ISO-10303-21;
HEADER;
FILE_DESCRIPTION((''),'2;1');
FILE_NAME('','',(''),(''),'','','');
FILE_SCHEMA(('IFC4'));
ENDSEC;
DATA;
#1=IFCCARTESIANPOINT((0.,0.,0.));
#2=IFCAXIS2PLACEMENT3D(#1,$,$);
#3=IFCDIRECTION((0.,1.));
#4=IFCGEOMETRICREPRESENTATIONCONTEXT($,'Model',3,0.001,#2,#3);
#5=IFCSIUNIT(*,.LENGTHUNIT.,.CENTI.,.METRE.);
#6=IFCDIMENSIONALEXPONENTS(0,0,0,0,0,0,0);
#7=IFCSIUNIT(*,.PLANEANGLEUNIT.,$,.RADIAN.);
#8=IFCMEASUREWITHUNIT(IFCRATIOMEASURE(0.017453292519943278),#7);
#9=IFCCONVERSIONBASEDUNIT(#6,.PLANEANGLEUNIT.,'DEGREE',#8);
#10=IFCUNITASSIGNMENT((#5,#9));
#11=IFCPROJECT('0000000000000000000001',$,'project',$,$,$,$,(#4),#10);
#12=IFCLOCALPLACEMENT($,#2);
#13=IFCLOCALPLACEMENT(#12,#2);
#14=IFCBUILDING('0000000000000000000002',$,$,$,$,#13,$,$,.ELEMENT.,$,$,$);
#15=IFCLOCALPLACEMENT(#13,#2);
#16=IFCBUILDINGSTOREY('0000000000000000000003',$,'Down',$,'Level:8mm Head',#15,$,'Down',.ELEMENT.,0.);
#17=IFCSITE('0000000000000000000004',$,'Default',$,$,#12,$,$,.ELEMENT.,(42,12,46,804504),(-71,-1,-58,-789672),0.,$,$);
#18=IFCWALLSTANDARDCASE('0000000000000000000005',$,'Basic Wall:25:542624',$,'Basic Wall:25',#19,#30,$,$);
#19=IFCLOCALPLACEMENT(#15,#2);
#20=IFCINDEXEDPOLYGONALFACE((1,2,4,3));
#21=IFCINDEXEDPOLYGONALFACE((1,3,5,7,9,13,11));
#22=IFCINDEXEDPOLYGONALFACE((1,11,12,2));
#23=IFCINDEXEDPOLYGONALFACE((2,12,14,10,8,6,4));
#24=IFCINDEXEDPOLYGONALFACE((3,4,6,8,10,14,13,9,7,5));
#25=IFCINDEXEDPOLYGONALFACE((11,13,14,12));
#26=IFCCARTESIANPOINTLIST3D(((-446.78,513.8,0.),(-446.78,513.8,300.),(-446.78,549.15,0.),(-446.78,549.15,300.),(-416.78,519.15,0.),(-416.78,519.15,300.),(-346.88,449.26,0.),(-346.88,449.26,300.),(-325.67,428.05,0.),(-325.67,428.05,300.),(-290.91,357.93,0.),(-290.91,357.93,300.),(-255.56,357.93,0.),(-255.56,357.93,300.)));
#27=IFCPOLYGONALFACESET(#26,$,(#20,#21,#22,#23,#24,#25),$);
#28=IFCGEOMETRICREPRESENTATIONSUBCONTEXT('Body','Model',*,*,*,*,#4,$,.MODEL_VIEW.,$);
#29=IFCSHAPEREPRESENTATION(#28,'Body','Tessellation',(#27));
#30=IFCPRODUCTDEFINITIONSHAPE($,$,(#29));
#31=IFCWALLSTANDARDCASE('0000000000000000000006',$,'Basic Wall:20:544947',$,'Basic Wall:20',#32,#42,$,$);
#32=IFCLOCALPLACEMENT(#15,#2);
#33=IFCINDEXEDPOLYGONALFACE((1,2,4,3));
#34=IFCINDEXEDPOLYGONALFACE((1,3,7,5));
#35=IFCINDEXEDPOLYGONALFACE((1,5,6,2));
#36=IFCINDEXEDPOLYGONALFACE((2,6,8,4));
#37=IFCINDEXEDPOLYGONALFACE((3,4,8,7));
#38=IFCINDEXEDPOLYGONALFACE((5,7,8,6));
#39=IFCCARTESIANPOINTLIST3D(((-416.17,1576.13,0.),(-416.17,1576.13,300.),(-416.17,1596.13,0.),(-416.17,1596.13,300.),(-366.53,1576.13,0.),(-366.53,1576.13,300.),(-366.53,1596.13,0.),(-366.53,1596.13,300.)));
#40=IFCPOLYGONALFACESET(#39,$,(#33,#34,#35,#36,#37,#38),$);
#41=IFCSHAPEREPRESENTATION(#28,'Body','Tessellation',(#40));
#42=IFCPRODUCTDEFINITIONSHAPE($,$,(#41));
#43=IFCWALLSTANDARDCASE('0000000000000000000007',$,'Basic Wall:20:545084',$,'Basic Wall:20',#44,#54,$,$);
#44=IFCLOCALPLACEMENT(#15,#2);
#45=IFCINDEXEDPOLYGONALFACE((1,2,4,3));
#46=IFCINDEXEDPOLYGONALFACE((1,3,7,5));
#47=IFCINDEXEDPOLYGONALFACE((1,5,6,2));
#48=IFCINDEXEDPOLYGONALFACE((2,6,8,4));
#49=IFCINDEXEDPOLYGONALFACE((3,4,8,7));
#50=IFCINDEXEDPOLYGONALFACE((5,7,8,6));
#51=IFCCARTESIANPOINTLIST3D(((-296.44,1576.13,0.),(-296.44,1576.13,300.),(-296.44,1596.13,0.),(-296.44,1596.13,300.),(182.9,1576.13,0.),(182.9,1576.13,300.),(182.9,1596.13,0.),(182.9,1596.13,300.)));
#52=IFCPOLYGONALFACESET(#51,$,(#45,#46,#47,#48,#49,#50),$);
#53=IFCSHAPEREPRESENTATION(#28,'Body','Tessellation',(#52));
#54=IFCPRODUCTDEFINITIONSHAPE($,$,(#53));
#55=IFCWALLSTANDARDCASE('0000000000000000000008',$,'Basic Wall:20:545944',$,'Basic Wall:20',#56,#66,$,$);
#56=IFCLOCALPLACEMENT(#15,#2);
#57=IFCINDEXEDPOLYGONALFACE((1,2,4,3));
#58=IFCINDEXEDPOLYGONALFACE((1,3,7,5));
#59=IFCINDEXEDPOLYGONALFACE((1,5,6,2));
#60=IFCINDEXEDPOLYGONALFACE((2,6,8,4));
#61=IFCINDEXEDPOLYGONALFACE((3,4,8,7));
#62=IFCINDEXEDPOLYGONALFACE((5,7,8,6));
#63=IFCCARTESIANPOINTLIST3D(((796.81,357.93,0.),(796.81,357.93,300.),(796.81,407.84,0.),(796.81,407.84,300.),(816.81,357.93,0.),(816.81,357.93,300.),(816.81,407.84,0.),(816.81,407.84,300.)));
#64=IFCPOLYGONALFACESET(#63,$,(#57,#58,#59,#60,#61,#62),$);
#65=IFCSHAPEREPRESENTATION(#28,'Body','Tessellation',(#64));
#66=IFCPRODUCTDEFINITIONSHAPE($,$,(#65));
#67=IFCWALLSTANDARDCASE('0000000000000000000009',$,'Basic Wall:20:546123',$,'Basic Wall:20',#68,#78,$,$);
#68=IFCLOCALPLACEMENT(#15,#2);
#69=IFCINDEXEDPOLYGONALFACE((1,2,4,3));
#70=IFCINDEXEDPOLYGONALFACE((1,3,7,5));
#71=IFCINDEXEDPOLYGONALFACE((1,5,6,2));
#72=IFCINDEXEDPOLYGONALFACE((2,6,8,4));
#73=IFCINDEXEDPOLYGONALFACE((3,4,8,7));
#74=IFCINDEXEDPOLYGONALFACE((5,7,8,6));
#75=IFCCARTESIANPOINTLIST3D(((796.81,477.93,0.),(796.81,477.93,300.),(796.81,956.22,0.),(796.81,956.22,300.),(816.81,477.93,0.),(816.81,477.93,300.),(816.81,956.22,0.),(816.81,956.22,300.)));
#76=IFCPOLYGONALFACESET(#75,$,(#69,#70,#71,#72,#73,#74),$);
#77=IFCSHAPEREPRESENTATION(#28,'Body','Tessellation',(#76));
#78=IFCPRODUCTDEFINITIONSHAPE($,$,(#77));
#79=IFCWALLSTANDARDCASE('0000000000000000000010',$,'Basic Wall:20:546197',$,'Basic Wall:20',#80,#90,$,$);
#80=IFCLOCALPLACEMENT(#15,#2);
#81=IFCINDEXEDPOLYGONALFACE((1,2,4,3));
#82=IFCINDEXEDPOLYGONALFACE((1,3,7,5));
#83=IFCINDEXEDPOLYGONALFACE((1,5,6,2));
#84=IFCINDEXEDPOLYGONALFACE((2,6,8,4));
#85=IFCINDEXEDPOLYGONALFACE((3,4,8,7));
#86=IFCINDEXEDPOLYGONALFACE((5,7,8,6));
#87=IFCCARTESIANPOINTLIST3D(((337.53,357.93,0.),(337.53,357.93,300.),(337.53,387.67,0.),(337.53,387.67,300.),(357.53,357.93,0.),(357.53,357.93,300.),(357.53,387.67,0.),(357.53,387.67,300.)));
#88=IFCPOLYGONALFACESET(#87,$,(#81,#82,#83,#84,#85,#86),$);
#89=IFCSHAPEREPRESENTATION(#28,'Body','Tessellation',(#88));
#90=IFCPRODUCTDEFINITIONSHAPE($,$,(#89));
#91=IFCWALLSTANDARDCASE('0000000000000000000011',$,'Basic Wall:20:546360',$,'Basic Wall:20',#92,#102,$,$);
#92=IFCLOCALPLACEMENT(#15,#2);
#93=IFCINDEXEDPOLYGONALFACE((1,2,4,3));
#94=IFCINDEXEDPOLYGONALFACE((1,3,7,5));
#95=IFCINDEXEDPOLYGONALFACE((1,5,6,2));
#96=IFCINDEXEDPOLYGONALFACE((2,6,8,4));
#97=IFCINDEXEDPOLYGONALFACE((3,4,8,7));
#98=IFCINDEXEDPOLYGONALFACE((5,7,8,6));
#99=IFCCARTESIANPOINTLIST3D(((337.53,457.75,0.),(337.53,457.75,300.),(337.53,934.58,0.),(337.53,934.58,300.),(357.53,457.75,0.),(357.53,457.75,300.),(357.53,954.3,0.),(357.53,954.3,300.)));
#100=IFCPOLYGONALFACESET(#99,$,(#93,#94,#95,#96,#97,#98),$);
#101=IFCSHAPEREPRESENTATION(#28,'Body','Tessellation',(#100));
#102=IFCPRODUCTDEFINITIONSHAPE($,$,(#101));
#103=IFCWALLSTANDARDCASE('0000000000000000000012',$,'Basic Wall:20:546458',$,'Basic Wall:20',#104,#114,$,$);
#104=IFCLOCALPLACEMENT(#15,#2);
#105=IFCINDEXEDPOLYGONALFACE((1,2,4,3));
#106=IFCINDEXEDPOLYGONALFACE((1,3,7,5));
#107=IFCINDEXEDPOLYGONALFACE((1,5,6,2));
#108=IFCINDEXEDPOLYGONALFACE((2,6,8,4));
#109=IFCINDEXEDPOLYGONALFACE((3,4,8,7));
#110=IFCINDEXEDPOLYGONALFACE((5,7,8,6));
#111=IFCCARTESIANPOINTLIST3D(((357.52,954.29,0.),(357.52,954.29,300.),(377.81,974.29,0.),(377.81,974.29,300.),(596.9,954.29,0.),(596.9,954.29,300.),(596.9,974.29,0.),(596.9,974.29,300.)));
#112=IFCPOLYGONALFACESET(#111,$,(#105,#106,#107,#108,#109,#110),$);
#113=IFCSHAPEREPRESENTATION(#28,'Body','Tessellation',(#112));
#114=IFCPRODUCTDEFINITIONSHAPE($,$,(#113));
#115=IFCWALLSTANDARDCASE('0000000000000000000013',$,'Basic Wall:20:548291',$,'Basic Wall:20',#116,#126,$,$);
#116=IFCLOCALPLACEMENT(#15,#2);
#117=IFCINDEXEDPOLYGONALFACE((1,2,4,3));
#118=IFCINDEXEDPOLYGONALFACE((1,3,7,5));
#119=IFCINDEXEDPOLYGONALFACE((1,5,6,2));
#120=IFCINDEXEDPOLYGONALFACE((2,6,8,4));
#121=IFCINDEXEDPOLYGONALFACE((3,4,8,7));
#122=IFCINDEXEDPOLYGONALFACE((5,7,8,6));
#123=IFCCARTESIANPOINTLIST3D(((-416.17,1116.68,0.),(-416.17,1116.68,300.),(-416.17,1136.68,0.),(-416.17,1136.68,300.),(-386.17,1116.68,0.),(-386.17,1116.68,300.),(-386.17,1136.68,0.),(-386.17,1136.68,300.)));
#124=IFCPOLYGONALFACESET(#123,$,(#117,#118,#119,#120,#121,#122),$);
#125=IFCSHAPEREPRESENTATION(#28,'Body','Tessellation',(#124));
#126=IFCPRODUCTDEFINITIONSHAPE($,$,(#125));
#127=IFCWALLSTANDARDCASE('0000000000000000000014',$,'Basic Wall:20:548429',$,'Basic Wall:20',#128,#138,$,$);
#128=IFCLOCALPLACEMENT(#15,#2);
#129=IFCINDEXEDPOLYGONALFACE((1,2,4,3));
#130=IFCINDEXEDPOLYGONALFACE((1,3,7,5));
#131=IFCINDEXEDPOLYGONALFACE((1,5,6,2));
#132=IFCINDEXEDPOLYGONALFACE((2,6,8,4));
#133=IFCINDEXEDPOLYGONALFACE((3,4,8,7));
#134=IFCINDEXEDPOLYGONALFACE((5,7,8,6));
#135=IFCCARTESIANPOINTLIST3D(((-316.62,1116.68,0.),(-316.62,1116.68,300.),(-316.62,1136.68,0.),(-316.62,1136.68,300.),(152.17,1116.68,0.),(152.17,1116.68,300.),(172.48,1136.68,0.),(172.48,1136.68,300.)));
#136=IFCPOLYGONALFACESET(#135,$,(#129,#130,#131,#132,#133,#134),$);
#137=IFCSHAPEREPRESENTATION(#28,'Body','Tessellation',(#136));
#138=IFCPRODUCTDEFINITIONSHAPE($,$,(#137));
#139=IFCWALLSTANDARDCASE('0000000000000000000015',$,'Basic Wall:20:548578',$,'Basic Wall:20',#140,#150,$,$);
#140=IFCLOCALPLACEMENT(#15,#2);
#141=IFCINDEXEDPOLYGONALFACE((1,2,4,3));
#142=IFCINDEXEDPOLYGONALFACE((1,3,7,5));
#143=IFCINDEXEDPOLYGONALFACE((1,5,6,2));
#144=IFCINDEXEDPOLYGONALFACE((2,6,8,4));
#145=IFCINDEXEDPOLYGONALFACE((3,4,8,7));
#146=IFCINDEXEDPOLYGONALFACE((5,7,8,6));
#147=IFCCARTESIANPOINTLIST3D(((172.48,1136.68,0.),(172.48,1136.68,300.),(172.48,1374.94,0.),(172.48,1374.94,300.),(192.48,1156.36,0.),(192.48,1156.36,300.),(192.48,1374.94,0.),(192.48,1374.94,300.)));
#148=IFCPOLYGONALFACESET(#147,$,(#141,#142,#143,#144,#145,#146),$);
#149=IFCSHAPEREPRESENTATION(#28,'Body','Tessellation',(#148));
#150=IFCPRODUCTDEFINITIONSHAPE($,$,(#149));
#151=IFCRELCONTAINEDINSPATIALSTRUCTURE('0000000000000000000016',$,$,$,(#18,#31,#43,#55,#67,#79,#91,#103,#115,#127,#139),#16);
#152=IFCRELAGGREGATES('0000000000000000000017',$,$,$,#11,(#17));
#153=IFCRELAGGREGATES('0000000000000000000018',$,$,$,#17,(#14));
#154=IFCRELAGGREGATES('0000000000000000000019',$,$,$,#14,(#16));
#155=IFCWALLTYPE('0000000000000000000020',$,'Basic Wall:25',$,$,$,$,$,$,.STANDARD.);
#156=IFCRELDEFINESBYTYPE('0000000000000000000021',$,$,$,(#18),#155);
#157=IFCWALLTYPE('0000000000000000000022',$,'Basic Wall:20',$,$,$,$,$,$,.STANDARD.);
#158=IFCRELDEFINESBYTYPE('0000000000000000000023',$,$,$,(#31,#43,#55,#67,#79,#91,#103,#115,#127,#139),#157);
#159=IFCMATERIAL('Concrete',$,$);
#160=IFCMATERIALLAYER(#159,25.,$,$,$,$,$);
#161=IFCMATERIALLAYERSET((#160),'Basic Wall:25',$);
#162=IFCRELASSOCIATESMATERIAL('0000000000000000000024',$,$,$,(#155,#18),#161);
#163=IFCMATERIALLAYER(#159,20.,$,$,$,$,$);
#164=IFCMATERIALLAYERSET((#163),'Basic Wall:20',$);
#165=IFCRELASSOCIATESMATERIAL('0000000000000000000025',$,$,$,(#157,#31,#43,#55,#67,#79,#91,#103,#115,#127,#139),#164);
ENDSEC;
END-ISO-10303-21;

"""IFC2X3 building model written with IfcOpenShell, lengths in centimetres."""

from ifc_helpers import new_model, entity, si_unit, converted_unit, direction, frame, frame_2d, origin, place, context, subcontext, project, spatial, polyline, rectangle, outline, extrude, material, layer, layer_set, layer_usage, type_object, element, save


model = new_model("IFC2X3")

# Units and contexts
model_context = context("Model", 3, precision=0.001, world=origin(), true_north=direction((0.0, 1.0)))
body_context = subcontext(model_context, "Body", "Model", "MODEL_VIEW")
ifc_project = project(units=[si_unit("LENGTHUNIT", "METRE", prefix="CENTI"), converted_unit("PLANEANGLEUNIT", "DEGREE", entity("IfcRatioMeasure", 0.017453292519943278), si_unit("PLANEANGLEUNIT", "RADIAN"), dimensions=[0, 0, 0, 0, 0, 0, 0])], contexts=[model_context])

# Site, building, storey
site_placement = place(None, origin())
site = spatial("IfcSite", under=ifc_project, at=site_placement, Name="Default", CompositionType="ELEMENT", RefLatitude=(42, 12, 46, 804504), RefLongitude=(-71, -1, -58, -789672), RefElevation=0.0)
building_placement = place(site_placement, origin())
building = spatial("IfcBuilding", under=site, at=building_placement, CompositionType="ELEMENT")
storey_placement = place(building_placement, origin())
storey = spatial("IfcBuildingStorey", under=building, at=storey_placement, Name="Down", ObjectType="Level:8mm Head", LongName="Down", CompositionType="ELEMENT", Elevation=0.0)

# Walls
ifc_material = material(Name="Concrete")
ifc_layer_1 = layer(ifc_material, 25.0)
ifc_layer_set_1 = layer_set([ifc_layer_1], Name="Basic Wall:25")
ifc_layer_usage_1 = layer_usage(ifc_layer_set_1, "AXIS2", "POSITIVE", -12.5)
wall_type_1 = type_object("IfcWallType", Name="Basic Wall:25", PredefinedType="STANDARD", material=ifc_layer_set_1)
wall_1_placement = place(storey_placement, frame((-264.39, 349.1, 0.0), z_axis=(0.0, 0.0, 1.0), x_axis=(-0.707107, 0.707107, 0.0)))
element("IfcWallStandardCase", 1, at=wall_1_placement, inside=storey, type_object=wall_type_1, material=ifc_layer_usage_1, Name="Basic Wall:25:542624", ObjectType="Basic Wall:25", context=body_context, shape_type="SweptSolid", body=[
    extrude(outline(polyline([(270.43, -12.5), (245.43, 12.5), (25.0, 12.5), (0.0, -12.5), (99.15, -12.5), (129.15, -12.5), (228.0, -12.5), (270.43, -12.5)])), origin(), (0.0, 0.0, 1.0), 300.0),
])
ifc_layer_2 = layer(ifc_material, 20.0)
ifc_layer_set_2 = layer_set([ifc_layer_2], Name="Basic Wall:20")
ifc_layer_usage_2 = layer_usage(ifc_layer_set_2, "AXIS2", "NEGATIVE", 10.0)
wall_type_2 = type_object("IfcWallType", Name="Basic Wall:20", PredefinedType="STANDARD", material=ifc_layer_set_2)
wall_2_placement = place(storey_placement, frame((-416.17, 1586.13, 0.0)))
element("IfcWallStandardCase", 2, at=wall_2_placement, inside=storey, type_object=wall_type_2, material=ifc_layer_usage_2, Name="Basic Wall:20:544947", ObjectType="Basic Wall:20", context=body_context, shape_type="SweptSolid", body=[
    extrude(rectangle(XDim=49.64, YDim=20.0, at=frame_2d((24.82, 0.0), x_axis=(-1.0, 0.0))), origin(), (0.0, 0.0, 1.0), 300.0),
])
ifc_layer_usage_3 = layer_usage(ifc_layer_set_2, "AXIS2", "NEGATIVE", 10.0)
wall_3_placement = place(storey_placement, frame((-296.44, 1586.13, 0.0)))
element("IfcWallStandardCase", 3, at=wall_3_placement, inside=storey, type_object=wall_type_2, material=ifc_layer_usage_3, Name="Basic Wall:20:545084", ObjectType="Basic Wall:20", context=body_context, shape_type="SweptSolid", body=[
    extrude(rectangle(XDim=479.34, YDim=20.0, at=frame_2d((239.67, 0.0), x_axis=(-1.0, 0.0))), origin(), (0.0, 0.0, 1.0), 300.0),
])
ifc_layer_usage_4 = layer_usage(ifc_layer_set_2, "AXIS2", "NEGATIVE", 10.0)
wall_4_placement = place(storey_placement, frame((806.81, 357.93, 0.0), z_axis=(0.0, 0.0, 1.0), x_axis=(0.0, 1.0, 0.0)))
element("IfcWallStandardCase", 4, at=wall_4_placement, inside=storey, type_object=wall_type_2, material=ifc_layer_usage_4, Name="Basic Wall:20:545944", ObjectType="Basic Wall:20", context=body_context, shape_type="SweptSolid", body=[
    extrude(rectangle(XDim=49.91, YDim=20.0, at=frame_2d((24.96, 0.0), x_axis=(-1.0, 0.0))), origin(), (0.0, 0.0, 1.0), 300.0),
])
ifc_layer_usage_5 = layer_usage(ifc_layer_set_2, "AXIS2", "NEGATIVE", 10.0)
wall_5_placement = place(storey_placement, frame((806.81, 477.93, 0.0), z_axis=(0.0, 0.0, 1.0), x_axis=(0.0, 1.0, 0.0)))
element("IfcWallStandardCase", 5, at=wall_5_placement, inside=storey, type_object=wall_type_2, material=ifc_layer_usage_5, Name="Basic Wall:20:546123", ObjectType="Basic Wall:20", context=body_context, shape_type="SweptSolid", body=[
    extrude(rectangle(XDim=478.28, YDim=20.0, at=frame_2d((239.14, 0.0), x_axis=(-1.0, 0.0))), origin(), (0.0, 0.0, 1.0), 300.0),
])
ifc_layer_usage_6 = layer_usage(ifc_layer_set_2, "AXIS2", "NEGATIVE", 10.0)
wall_6_placement = place(storey_placement, frame((347.53, 357.93, 0.0), z_axis=(0.0, 0.0, 1.0), x_axis=(0.0, 1.0, 0.0)))
element("IfcWallStandardCase", 6, at=wall_6_placement, inside=storey, type_object=wall_type_2, material=ifc_layer_usage_6, Name="Basic Wall:20:546197", ObjectType="Basic Wall:20", context=body_context, shape_type="SweptSolid", body=[
    extrude(rectangle(XDim=29.73, YDim=20.0, at=frame_2d((14.87, 0.0), x_axis=(-1.0, 0.0))), origin(), (0.0, 0.0, 1.0), 300.0),
])
ifc_layer_usage_7 = layer_usage(ifc_layer_set_2, "AXIS2", "NEGATIVE", 10.0)
wall_7_placement = place(storey_placement, frame((347.53, 457.75, 0.0), z_axis=(0.0, 0.0, 1.0), x_axis=(0.0, 1.0, 0.0)))
element("IfcWallStandardCase", 7, at=wall_7_placement, inside=storey, type_object=wall_type_2, material=ifc_layer_usage_7, Name="Basic Wall:20:546360", ObjectType="Basic Wall:20", context=body_context, shape_type="SweptSolid", body=[
    extrude(outline(polyline([(496.54, -10.0), (476.83, 10.0), (0.0, 10.0), (0.0, -10.0), (496.54, -10.0)])), origin(), (0.0, 0.0, 1.0), 300.0),
])
ifc_layer_usage_8 = layer_usage(ifc_layer_set_2, "AXIS2", "POSITIVE", -10.0)
wall_8_placement = place(storey_placement, frame((357.52, 964.29, 0.0)))
element("IfcWallStandardCase", 8, at=wall_8_placement, inside=storey, type_object=wall_type_2, material=ifc_layer_usage_8, Name="Basic Wall:20:546458", ObjectType="Basic Wall:20", context=body_context, shape_type="SweptSolid", body=[
    extrude(outline(polyline([(239.38, -10.0), (239.38, 10.0), (20.29, 10.0), (0.0, -10.0), (239.38, -10.0)])), origin(), (0.0, 0.0, 1.0), 300.0),
])
ifc_layer_usage_9 = layer_usage(ifc_layer_set_2, "AXIS2", "NEGATIVE", 10.0)
wall_9_placement = place(storey_placement, frame((-386.17, 1126.68, 0.0), z_axis=(0.0, 0.0, 1.0), x_axis=(-1.0, 0.0, 0.0)))
element("IfcWallStandardCase", 9, at=wall_9_placement, inside=storey, type_object=wall_type_2, material=ifc_layer_usage_9, Name="Basic Wall:20:548291", ObjectType="Basic Wall:20", context=body_context, shape_type="SweptSolid", body=[
    extrude(rectangle(XDim=30.0, YDim=20.0, at=frame_2d((15.0, 0.0), x_axis=(-1.0, 0.0))), origin(), (0.0, 0.0, 1.0), 300.0),
])
ifc_layer_usage_10 = layer_usage(ifc_layer_set_2, "AXIS2", "POSITIVE", -10.0)
wall_10_placement = place(storey_placement, frame((-316.62, 1126.68, 0.0)))
element("IfcWallStandardCase", 10, at=wall_10_placement, inside=storey, type_object=wall_type_2, material=ifc_layer_usage_10, Name="Basic Wall:20:548429", ObjectType="Basic Wall:20", context=body_context, shape_type="SweptSolid", body=[
    extrude(outline(polyline([(468.78, -10.0), (489.1, 10.0), (0.0, 10.0), (0.0, -10.0), (468.78, -10.0)])), origin(), (0.0, 0.0, 1.0), 300.0),
])
ifc_layer_usage_11 = layer_usage(ifc_layer_set_2, "AXIS2", "NEGATIVE", 10.0)
wall_11_placement = place(storey_placement, frame((182.48, 1136.68, 0.0), z_axis=(0.0, 0.0, 1.0), x_axis=(0.0, 1.0, 0.0)))
element("IfcWallStandardCase", 11, at=wall_11_placement, inside=storey, type_object=wall_type_2, material=ifc_layer_usage_11, Name="Basic Wall:20:548578", ObjectType="Basic Wall:20", context=body_context, shape_type="SweptSolid", body=[
    extrude(outline(polyline([(238.26, -10.0), (238.26, 10.0), (0.0, 10.0), (19.69, -10.0), (238.26, -10.0)])), origin(), (0.0, 0.0, 1.0), 300.0),
])

save(model, "model.ifc")
